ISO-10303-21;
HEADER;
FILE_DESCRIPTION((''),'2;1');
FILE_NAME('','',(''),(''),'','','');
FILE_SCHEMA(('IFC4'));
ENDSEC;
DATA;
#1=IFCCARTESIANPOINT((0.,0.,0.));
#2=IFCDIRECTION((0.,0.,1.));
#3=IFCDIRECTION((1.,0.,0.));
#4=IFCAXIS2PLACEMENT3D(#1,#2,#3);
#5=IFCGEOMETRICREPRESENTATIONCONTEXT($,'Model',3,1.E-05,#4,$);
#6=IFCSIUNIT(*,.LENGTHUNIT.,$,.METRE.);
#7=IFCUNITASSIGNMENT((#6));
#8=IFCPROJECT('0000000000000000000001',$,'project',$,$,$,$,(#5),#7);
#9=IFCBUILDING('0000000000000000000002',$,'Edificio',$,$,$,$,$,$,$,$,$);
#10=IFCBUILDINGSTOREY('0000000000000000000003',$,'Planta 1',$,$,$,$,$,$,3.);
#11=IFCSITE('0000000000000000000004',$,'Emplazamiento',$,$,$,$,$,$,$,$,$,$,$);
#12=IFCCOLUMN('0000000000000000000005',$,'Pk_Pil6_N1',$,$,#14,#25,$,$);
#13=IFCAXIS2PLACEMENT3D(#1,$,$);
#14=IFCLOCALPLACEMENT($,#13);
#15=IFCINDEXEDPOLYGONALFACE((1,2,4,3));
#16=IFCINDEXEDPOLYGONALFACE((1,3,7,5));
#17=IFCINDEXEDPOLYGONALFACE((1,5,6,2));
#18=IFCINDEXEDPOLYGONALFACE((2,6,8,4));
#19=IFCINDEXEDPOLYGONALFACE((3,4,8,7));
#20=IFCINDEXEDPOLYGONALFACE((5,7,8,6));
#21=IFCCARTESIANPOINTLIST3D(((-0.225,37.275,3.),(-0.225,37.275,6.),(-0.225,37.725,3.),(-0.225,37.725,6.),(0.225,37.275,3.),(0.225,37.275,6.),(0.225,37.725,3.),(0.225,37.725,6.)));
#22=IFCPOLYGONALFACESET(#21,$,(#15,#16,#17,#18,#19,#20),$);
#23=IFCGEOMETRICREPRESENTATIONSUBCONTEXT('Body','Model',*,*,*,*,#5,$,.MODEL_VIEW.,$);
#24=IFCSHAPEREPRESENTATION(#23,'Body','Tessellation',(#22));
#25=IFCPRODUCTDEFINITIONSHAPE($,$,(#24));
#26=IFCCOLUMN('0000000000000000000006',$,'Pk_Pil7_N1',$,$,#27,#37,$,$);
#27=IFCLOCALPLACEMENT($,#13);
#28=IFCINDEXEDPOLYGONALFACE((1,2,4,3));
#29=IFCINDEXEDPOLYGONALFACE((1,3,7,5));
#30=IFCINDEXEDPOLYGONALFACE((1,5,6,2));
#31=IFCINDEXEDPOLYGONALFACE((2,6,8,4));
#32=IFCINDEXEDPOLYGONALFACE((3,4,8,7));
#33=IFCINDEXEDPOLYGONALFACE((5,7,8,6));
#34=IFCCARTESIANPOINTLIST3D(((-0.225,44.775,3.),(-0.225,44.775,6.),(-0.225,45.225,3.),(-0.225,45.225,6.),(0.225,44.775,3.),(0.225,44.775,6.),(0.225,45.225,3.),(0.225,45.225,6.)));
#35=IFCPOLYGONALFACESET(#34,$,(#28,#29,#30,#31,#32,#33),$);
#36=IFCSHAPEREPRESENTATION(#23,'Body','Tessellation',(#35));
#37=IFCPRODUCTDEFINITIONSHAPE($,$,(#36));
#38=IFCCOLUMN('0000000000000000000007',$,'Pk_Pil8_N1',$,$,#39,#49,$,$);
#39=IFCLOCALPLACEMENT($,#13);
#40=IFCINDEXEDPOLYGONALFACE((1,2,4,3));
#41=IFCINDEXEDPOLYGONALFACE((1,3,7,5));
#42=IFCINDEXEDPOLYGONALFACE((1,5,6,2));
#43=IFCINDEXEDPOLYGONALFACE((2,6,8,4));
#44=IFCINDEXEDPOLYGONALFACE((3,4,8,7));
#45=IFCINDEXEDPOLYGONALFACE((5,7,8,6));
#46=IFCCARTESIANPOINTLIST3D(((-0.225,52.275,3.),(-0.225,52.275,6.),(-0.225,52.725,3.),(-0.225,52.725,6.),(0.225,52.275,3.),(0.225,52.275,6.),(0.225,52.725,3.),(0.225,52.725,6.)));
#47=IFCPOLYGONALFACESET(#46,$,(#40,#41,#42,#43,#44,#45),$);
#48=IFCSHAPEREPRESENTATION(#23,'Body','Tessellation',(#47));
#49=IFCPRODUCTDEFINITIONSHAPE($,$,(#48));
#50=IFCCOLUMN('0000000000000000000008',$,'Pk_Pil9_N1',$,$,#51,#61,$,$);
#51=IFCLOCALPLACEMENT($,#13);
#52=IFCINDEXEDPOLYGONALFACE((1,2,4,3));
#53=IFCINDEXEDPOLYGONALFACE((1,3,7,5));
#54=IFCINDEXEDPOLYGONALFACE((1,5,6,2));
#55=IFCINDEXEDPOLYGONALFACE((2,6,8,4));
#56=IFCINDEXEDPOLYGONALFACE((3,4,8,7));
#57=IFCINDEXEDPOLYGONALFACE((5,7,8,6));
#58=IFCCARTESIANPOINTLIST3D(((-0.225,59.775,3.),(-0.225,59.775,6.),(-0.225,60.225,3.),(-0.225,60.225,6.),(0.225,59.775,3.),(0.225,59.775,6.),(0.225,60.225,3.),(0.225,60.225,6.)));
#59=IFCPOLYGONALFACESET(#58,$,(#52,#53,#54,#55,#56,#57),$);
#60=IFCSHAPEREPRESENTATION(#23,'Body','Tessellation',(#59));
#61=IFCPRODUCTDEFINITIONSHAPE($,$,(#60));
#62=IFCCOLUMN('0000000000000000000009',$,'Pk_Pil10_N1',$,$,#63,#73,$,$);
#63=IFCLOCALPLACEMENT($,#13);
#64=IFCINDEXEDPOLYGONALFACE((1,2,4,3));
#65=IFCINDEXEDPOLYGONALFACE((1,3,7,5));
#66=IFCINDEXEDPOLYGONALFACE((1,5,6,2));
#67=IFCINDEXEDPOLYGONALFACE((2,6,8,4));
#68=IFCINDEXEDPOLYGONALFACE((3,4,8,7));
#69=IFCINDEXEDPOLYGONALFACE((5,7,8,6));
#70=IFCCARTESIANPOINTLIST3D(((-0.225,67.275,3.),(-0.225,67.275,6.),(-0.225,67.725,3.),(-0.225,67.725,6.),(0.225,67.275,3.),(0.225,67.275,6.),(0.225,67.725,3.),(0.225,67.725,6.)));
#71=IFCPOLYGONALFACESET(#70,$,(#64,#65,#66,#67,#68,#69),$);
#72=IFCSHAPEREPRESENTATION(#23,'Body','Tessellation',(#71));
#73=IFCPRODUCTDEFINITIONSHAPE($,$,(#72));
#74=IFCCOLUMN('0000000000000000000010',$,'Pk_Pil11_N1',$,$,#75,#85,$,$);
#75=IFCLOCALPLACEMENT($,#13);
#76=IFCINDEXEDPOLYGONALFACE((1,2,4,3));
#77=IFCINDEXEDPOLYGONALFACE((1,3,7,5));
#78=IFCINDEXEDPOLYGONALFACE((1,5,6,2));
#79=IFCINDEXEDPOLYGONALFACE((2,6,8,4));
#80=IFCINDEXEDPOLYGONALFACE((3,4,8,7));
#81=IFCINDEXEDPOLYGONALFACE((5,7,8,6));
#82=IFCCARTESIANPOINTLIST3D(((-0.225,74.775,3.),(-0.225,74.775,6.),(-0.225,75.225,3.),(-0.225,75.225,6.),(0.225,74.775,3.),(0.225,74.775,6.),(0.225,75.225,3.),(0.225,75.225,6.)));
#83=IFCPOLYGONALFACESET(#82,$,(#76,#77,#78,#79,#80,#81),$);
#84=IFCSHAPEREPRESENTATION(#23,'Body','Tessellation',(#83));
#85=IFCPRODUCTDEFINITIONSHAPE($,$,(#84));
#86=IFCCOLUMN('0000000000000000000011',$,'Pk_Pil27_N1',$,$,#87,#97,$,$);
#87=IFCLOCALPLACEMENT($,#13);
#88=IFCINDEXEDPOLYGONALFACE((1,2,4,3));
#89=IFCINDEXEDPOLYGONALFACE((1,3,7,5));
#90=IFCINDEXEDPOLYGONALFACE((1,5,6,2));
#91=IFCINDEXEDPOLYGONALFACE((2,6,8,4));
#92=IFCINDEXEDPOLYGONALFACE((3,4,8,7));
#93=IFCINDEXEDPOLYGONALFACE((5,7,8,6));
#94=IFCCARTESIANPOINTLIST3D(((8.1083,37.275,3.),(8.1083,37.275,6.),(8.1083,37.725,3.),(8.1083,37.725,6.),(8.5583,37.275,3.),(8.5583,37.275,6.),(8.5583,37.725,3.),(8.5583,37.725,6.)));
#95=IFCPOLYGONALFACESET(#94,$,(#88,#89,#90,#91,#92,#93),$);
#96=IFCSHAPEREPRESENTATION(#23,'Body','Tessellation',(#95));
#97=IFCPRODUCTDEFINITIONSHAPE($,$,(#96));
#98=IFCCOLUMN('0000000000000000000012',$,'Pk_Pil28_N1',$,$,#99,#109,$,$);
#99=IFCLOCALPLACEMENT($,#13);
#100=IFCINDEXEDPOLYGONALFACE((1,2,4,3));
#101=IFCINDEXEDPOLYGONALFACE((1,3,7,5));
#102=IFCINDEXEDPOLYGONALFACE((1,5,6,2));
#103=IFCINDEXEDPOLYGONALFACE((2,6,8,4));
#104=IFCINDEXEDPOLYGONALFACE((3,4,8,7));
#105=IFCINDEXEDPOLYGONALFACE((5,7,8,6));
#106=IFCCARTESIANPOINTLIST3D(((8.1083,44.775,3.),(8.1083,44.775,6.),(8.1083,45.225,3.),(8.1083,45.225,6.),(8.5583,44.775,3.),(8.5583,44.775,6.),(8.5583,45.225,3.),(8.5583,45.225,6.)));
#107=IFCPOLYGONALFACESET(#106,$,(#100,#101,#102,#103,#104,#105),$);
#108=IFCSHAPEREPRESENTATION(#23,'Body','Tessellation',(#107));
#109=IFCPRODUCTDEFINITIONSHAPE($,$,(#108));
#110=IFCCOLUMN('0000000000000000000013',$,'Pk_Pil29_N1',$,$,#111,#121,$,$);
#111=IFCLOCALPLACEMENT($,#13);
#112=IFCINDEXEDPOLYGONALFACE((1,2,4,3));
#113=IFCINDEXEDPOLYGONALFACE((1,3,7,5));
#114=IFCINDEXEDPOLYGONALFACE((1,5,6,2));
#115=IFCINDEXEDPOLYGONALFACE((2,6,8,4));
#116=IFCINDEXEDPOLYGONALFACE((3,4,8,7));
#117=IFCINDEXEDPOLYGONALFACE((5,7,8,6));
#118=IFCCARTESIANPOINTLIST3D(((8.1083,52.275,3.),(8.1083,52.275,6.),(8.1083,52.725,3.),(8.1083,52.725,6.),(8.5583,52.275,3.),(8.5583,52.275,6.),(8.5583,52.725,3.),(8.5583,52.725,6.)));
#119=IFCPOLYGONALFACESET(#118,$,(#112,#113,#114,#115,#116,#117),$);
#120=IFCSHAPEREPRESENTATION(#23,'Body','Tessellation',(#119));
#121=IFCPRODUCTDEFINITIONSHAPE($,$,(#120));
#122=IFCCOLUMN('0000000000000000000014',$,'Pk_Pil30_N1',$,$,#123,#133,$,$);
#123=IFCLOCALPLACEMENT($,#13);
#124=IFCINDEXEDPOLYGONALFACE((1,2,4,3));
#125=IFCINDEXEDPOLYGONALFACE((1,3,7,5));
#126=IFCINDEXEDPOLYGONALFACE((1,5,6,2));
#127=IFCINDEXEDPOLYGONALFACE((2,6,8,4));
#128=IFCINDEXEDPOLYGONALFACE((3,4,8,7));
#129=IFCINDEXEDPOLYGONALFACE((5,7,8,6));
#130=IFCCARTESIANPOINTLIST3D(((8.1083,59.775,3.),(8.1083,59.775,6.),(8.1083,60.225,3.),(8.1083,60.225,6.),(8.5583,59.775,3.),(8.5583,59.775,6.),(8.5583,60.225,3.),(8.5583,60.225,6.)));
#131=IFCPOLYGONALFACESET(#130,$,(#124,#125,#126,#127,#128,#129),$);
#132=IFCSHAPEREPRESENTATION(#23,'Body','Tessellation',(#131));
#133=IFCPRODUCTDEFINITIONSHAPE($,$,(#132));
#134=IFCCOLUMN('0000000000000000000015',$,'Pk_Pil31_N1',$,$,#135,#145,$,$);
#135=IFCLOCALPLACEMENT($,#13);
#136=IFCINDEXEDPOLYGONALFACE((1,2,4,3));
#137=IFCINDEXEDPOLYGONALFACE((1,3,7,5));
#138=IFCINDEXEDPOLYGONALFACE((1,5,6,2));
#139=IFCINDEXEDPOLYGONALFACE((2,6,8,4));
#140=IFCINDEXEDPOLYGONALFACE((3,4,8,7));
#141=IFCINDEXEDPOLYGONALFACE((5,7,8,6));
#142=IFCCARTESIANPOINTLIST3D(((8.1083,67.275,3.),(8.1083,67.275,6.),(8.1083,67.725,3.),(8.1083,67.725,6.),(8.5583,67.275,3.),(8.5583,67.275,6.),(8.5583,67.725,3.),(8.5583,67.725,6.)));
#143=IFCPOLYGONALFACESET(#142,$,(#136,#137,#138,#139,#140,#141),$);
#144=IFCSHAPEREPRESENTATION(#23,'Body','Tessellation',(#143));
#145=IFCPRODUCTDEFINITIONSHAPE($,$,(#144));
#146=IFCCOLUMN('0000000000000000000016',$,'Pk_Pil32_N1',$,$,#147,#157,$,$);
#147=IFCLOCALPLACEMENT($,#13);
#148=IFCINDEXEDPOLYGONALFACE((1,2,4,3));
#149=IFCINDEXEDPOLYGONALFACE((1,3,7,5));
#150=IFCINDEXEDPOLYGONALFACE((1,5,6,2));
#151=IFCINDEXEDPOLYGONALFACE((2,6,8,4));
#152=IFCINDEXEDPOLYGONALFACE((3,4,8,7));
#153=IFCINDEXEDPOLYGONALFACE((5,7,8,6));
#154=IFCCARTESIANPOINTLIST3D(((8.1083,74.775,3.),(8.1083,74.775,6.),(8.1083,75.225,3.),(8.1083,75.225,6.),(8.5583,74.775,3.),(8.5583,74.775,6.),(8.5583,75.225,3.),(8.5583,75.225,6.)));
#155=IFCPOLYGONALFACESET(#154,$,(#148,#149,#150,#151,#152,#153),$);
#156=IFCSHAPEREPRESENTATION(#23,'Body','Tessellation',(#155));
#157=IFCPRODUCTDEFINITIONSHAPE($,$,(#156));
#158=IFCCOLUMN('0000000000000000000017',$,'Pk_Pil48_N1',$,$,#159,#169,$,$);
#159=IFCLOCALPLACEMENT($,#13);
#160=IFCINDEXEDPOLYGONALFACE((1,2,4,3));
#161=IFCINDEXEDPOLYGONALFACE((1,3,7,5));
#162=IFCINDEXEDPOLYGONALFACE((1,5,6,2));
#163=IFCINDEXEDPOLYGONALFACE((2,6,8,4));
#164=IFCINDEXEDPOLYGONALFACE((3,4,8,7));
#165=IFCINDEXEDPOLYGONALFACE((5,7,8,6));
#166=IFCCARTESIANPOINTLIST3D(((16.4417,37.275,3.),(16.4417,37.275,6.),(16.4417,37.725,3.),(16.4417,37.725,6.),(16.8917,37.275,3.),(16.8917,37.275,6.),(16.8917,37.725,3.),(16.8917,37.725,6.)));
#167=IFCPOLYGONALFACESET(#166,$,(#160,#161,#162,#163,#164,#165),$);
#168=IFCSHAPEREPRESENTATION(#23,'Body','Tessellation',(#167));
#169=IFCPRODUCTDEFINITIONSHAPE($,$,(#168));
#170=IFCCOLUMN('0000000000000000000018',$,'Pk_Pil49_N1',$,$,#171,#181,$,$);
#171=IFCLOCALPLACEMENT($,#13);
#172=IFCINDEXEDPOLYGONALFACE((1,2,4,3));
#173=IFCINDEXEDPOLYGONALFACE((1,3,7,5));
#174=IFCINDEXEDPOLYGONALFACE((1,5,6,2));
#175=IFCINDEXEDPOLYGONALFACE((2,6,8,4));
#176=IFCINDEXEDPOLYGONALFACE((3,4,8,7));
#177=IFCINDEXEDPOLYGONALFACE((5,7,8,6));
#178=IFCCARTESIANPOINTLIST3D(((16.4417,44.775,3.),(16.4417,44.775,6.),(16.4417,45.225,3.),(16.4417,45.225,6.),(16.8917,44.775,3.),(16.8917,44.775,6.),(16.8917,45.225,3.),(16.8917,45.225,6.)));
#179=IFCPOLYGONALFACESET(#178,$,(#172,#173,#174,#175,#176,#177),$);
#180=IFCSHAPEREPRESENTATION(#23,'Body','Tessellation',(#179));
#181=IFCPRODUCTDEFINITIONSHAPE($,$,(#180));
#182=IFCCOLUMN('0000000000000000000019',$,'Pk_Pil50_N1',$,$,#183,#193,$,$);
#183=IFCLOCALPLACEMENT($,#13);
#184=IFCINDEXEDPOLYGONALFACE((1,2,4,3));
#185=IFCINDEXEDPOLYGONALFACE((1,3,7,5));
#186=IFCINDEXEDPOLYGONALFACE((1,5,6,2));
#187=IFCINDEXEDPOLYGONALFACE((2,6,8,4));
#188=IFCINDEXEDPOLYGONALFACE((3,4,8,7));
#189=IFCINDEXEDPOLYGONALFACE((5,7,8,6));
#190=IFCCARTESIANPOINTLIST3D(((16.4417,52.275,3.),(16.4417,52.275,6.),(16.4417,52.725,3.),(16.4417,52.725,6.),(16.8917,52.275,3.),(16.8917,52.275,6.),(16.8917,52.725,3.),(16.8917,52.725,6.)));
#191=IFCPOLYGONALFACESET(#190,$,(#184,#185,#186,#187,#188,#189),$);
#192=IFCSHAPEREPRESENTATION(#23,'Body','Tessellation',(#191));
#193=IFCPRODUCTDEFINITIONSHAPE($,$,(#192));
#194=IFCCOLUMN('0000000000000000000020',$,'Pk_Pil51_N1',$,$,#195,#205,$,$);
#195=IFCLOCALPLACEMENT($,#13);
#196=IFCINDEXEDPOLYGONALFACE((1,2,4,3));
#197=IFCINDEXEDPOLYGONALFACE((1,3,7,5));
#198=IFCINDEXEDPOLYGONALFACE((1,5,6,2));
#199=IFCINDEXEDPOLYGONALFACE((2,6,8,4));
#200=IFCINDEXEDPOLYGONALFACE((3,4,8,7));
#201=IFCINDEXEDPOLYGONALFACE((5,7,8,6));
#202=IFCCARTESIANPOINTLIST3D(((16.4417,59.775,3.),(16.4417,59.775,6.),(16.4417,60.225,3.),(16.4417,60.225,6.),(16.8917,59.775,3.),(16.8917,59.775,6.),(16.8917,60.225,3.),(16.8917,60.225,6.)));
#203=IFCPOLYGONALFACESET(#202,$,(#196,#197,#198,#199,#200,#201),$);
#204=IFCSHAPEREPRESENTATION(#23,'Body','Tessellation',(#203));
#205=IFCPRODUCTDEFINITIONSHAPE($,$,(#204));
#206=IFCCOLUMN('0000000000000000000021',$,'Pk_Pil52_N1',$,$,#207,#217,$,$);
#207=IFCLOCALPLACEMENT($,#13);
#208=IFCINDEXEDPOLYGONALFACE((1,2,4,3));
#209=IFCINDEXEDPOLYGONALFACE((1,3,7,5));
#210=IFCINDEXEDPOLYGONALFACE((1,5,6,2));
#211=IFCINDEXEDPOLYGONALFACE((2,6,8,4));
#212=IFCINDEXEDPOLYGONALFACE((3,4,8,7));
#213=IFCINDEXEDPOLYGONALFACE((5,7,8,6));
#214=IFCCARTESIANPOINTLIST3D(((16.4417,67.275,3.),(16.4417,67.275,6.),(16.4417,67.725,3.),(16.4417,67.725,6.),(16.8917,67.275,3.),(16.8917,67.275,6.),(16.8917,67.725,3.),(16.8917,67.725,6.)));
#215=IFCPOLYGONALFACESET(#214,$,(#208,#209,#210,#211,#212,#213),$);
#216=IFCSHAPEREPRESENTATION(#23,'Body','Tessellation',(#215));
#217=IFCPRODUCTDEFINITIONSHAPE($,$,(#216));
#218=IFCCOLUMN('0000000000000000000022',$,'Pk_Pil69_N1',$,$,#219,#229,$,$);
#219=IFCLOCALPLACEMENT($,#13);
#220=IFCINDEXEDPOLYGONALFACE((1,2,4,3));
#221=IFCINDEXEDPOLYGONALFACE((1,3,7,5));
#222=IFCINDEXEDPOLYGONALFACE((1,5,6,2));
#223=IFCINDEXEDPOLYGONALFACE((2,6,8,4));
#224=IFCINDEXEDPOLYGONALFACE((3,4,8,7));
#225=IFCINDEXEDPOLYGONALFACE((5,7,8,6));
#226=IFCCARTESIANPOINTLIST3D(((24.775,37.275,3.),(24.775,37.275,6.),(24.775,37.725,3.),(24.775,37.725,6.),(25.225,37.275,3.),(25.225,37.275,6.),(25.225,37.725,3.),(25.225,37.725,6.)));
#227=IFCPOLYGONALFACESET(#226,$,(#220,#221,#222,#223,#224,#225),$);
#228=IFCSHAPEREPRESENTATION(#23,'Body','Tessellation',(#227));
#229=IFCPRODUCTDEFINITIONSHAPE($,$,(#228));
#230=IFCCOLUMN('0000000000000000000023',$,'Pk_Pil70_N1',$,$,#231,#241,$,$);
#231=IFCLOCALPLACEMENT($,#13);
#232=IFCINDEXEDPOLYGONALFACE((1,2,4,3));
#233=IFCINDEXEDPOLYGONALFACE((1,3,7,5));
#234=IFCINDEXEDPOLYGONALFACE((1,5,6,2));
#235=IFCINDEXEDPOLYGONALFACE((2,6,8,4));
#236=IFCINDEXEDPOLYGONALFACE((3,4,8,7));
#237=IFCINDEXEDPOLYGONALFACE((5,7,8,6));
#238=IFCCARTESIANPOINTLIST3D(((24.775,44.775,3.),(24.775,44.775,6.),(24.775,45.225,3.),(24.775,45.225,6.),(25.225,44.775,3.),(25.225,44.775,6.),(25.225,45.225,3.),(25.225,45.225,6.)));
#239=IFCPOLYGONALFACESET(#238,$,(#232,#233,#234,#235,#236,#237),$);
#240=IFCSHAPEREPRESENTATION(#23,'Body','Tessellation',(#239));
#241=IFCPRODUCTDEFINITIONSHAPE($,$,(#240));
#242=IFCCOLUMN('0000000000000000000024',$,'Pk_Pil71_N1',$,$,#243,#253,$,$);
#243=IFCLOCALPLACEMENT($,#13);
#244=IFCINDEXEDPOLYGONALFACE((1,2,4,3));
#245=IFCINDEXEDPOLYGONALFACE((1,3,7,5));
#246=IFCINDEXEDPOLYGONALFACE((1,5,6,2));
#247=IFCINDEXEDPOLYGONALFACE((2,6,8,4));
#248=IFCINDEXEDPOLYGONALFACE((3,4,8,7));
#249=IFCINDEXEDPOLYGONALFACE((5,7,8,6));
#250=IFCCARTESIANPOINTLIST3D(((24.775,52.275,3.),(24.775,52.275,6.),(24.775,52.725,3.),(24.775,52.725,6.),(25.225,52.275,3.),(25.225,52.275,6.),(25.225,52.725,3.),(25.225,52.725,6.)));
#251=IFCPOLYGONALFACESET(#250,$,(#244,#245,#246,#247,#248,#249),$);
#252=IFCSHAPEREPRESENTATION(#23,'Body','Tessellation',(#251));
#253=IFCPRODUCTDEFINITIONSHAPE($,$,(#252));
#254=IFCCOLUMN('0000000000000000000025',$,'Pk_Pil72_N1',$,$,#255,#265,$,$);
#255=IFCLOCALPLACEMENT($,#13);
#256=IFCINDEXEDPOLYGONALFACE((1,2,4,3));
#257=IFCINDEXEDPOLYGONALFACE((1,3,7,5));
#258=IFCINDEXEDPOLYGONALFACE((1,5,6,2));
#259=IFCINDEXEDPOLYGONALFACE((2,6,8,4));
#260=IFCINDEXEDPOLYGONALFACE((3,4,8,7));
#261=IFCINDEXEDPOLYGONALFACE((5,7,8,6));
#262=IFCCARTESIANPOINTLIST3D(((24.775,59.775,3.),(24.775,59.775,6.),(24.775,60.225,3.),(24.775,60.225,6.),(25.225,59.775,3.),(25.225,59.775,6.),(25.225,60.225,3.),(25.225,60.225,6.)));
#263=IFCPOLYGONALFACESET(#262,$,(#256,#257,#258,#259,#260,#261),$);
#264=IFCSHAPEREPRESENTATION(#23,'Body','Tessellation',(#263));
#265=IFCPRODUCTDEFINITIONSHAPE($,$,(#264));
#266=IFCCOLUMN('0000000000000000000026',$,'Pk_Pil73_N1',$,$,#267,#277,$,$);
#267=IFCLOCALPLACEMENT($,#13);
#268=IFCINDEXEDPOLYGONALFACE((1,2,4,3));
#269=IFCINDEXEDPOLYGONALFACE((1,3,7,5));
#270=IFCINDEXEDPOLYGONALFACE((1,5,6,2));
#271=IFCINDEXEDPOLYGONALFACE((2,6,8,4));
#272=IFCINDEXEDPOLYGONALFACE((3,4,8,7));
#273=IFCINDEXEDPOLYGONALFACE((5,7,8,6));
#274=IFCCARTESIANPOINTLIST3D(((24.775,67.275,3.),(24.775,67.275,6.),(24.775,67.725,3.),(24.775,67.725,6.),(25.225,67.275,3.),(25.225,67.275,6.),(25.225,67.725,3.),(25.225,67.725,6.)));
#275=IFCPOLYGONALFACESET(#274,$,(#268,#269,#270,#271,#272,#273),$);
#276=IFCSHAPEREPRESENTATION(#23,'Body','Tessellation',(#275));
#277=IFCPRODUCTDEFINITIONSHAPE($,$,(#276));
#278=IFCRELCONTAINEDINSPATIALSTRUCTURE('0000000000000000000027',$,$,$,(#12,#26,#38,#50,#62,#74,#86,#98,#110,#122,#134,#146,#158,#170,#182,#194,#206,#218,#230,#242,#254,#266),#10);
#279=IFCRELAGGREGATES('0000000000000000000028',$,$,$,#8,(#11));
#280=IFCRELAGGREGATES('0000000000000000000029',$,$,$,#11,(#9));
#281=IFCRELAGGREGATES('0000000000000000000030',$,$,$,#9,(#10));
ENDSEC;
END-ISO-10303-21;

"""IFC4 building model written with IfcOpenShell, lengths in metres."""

from ifc_helpers import new_model, si_unit, frame, origin_with_axes, origin_2d, place, context, subcontext, project, spatial, rectangle, extrude, element, save


model = new_model("IFC4")

# Units and contexts
model_context = context("Model", 3, precision=1e-05, world=origin_with_axes())
body_context = subcontext(model_context, "Body", "Model", "MODEL_VIEW")
ifc_project = project(units=[si_unit("LENGTHUNIT", "METRE")], contexts=[model_context])

# Site, building, storey
site = spatial("IfcSite", under=ifc_project, Name="Emplazamiento")
building = spatial("IfcBuilding", under=site, Name="Edificio")
storey = spatial("IfcBuildingStorey", under=building, Name="Planta 1", Elevation=3.0)

# Columns
for number, where, z_axis, x_axis, name in (
    (1, (0.0, 37.5, 3.0), (0.0, 0.0, 1.0), (1.0, 0.0, 0.0), "Pk_Pil6_N1"),
    (2, (0.0, 45.0, 3.0), (0.0, 0.0, 1.0), (1.0, 0.0, 0.0), "Pk_Pil7_N1"),
    (3, (0.0, 52.5, 3.0), (0.0, 0.0, 1.0), (1.0, 0.0, 0.0), "Pk_Pil8_N1"),
    (4, (0.0, 60.0, 3.0), (0.0, 0.0, 1.0), (1.0, 0.0, 0.0), "Pk_Pil9_N1"),
    (5, (0.0, 67.5, 3.0), (0.0, 0.0, 1.0), (1.0, 0.0, 0.0), "Pk_Pil10_N1"),
    (6, (0.0, 75.0, 3.0), (0.0, 0.0, 1.0), (1.0, 0.0, 0.0), "Pk_Pil11_N1"),
    (7, (8.3333, 37.5, 3.0), (0.0, 0.0, 1.0), (1.0, 0.0, 0.0), "Pk_Pil27_N1"),
    (8, (8.3333, 45.0, 3.0), (0.0, 0.0, 1.0), (1.0, 0.0, 0.0), "Pk_Pil28_N1"),
    (9, (8.3333, 52.5, 3.0), (0.0, 0.0, 1.0), (1.0, 0.0, 0.0), "Pk_Pil29_N1"),
    (10, (8.3333, 60.0, 3.0), (0.0, 0.0, 1.0), (1.0, 0.0, 0.0), "Pk_Pil30_N1"),
    (11, (8.3333, 67.5, 3.0), (0.0, 0.0, 1.0), (1.0, 0.0, 0.0), "Pk_Pil31_N1"),
    (12, (8.3333, 75.0, 3.0), (0.0, 0.0, 1.0), (1.0, 0.0, 0.0), "Pk_Pil32_N1"),
    (13, (16.6667, 37.5, 3.0), (0.0, 0.0, 1.0), (1.0, 0.0, 0.0), "Pk_Pil48_N1"),
    (14, (16.6667, 45.0, 3.0), (0.0, 0.0, 1.0), (1.0, 0.0, 0.0), "Pk_Pil49_N1"),
    (15, (16.6667, 52.5, 3.0), (0.0, 0.0, 1.0), (1.0, 0.0, 0.0), "Pk_Pil50_N1"),
    (16, (16.6667, 60.0, 3.0), (0.0, 0.0, 1.0), (1.0, 0.0, 0.0), "Pk_Pil51_N1"),
    (17, (16.6667, 67.5, 3.0), (0.0, 0.0, 1.0), (1.0, 0.0, 0.0), "Pk_Pil52_N1"),
    (18, (25.0, 37.5, 3.0), (0.0, 0.0, 1.0), (1.0, 0.0, 0.0), "Pk_Pil69_N1"),
    (19, (25.0, 45.0, 3.0), (0.0, 0.0, 1.0), (1.0, 0.0, 0.0), "Pk_Pil70_N1"),
    (20, (25.0, 52.5, 3.0), (0.0, 0.0, 1.0), (1.0, 0.0, 0.0), "Pk_Pil71_N1"),
    (21, (25.0, 60.0, 3.0), (0.0, 0.0, 1.0), (1.0, 0.0, 0.0), "Pk_Pil72_N1"),
    (22, (25.0, 67.5, 3.0), (0.0, 0.0, 1.0), (1.0, 0.0, 0.0), "Pk_Pil73_N1"),
):
    element("IfcColumn", number, at=place(None, frame(where, z_axis=z_axis, x_axis=x_axis)), inside=storey, Name=name, context=body_context, shape_type="SweptSolid", body=[
        extrude(rectangle(XDim=0.45, YDim=0.45, at=origin_2d()), origin_with_axes(), (0.0, 0.0, 1.0), 3.0),
    ])

save(model, "model.ifc")
